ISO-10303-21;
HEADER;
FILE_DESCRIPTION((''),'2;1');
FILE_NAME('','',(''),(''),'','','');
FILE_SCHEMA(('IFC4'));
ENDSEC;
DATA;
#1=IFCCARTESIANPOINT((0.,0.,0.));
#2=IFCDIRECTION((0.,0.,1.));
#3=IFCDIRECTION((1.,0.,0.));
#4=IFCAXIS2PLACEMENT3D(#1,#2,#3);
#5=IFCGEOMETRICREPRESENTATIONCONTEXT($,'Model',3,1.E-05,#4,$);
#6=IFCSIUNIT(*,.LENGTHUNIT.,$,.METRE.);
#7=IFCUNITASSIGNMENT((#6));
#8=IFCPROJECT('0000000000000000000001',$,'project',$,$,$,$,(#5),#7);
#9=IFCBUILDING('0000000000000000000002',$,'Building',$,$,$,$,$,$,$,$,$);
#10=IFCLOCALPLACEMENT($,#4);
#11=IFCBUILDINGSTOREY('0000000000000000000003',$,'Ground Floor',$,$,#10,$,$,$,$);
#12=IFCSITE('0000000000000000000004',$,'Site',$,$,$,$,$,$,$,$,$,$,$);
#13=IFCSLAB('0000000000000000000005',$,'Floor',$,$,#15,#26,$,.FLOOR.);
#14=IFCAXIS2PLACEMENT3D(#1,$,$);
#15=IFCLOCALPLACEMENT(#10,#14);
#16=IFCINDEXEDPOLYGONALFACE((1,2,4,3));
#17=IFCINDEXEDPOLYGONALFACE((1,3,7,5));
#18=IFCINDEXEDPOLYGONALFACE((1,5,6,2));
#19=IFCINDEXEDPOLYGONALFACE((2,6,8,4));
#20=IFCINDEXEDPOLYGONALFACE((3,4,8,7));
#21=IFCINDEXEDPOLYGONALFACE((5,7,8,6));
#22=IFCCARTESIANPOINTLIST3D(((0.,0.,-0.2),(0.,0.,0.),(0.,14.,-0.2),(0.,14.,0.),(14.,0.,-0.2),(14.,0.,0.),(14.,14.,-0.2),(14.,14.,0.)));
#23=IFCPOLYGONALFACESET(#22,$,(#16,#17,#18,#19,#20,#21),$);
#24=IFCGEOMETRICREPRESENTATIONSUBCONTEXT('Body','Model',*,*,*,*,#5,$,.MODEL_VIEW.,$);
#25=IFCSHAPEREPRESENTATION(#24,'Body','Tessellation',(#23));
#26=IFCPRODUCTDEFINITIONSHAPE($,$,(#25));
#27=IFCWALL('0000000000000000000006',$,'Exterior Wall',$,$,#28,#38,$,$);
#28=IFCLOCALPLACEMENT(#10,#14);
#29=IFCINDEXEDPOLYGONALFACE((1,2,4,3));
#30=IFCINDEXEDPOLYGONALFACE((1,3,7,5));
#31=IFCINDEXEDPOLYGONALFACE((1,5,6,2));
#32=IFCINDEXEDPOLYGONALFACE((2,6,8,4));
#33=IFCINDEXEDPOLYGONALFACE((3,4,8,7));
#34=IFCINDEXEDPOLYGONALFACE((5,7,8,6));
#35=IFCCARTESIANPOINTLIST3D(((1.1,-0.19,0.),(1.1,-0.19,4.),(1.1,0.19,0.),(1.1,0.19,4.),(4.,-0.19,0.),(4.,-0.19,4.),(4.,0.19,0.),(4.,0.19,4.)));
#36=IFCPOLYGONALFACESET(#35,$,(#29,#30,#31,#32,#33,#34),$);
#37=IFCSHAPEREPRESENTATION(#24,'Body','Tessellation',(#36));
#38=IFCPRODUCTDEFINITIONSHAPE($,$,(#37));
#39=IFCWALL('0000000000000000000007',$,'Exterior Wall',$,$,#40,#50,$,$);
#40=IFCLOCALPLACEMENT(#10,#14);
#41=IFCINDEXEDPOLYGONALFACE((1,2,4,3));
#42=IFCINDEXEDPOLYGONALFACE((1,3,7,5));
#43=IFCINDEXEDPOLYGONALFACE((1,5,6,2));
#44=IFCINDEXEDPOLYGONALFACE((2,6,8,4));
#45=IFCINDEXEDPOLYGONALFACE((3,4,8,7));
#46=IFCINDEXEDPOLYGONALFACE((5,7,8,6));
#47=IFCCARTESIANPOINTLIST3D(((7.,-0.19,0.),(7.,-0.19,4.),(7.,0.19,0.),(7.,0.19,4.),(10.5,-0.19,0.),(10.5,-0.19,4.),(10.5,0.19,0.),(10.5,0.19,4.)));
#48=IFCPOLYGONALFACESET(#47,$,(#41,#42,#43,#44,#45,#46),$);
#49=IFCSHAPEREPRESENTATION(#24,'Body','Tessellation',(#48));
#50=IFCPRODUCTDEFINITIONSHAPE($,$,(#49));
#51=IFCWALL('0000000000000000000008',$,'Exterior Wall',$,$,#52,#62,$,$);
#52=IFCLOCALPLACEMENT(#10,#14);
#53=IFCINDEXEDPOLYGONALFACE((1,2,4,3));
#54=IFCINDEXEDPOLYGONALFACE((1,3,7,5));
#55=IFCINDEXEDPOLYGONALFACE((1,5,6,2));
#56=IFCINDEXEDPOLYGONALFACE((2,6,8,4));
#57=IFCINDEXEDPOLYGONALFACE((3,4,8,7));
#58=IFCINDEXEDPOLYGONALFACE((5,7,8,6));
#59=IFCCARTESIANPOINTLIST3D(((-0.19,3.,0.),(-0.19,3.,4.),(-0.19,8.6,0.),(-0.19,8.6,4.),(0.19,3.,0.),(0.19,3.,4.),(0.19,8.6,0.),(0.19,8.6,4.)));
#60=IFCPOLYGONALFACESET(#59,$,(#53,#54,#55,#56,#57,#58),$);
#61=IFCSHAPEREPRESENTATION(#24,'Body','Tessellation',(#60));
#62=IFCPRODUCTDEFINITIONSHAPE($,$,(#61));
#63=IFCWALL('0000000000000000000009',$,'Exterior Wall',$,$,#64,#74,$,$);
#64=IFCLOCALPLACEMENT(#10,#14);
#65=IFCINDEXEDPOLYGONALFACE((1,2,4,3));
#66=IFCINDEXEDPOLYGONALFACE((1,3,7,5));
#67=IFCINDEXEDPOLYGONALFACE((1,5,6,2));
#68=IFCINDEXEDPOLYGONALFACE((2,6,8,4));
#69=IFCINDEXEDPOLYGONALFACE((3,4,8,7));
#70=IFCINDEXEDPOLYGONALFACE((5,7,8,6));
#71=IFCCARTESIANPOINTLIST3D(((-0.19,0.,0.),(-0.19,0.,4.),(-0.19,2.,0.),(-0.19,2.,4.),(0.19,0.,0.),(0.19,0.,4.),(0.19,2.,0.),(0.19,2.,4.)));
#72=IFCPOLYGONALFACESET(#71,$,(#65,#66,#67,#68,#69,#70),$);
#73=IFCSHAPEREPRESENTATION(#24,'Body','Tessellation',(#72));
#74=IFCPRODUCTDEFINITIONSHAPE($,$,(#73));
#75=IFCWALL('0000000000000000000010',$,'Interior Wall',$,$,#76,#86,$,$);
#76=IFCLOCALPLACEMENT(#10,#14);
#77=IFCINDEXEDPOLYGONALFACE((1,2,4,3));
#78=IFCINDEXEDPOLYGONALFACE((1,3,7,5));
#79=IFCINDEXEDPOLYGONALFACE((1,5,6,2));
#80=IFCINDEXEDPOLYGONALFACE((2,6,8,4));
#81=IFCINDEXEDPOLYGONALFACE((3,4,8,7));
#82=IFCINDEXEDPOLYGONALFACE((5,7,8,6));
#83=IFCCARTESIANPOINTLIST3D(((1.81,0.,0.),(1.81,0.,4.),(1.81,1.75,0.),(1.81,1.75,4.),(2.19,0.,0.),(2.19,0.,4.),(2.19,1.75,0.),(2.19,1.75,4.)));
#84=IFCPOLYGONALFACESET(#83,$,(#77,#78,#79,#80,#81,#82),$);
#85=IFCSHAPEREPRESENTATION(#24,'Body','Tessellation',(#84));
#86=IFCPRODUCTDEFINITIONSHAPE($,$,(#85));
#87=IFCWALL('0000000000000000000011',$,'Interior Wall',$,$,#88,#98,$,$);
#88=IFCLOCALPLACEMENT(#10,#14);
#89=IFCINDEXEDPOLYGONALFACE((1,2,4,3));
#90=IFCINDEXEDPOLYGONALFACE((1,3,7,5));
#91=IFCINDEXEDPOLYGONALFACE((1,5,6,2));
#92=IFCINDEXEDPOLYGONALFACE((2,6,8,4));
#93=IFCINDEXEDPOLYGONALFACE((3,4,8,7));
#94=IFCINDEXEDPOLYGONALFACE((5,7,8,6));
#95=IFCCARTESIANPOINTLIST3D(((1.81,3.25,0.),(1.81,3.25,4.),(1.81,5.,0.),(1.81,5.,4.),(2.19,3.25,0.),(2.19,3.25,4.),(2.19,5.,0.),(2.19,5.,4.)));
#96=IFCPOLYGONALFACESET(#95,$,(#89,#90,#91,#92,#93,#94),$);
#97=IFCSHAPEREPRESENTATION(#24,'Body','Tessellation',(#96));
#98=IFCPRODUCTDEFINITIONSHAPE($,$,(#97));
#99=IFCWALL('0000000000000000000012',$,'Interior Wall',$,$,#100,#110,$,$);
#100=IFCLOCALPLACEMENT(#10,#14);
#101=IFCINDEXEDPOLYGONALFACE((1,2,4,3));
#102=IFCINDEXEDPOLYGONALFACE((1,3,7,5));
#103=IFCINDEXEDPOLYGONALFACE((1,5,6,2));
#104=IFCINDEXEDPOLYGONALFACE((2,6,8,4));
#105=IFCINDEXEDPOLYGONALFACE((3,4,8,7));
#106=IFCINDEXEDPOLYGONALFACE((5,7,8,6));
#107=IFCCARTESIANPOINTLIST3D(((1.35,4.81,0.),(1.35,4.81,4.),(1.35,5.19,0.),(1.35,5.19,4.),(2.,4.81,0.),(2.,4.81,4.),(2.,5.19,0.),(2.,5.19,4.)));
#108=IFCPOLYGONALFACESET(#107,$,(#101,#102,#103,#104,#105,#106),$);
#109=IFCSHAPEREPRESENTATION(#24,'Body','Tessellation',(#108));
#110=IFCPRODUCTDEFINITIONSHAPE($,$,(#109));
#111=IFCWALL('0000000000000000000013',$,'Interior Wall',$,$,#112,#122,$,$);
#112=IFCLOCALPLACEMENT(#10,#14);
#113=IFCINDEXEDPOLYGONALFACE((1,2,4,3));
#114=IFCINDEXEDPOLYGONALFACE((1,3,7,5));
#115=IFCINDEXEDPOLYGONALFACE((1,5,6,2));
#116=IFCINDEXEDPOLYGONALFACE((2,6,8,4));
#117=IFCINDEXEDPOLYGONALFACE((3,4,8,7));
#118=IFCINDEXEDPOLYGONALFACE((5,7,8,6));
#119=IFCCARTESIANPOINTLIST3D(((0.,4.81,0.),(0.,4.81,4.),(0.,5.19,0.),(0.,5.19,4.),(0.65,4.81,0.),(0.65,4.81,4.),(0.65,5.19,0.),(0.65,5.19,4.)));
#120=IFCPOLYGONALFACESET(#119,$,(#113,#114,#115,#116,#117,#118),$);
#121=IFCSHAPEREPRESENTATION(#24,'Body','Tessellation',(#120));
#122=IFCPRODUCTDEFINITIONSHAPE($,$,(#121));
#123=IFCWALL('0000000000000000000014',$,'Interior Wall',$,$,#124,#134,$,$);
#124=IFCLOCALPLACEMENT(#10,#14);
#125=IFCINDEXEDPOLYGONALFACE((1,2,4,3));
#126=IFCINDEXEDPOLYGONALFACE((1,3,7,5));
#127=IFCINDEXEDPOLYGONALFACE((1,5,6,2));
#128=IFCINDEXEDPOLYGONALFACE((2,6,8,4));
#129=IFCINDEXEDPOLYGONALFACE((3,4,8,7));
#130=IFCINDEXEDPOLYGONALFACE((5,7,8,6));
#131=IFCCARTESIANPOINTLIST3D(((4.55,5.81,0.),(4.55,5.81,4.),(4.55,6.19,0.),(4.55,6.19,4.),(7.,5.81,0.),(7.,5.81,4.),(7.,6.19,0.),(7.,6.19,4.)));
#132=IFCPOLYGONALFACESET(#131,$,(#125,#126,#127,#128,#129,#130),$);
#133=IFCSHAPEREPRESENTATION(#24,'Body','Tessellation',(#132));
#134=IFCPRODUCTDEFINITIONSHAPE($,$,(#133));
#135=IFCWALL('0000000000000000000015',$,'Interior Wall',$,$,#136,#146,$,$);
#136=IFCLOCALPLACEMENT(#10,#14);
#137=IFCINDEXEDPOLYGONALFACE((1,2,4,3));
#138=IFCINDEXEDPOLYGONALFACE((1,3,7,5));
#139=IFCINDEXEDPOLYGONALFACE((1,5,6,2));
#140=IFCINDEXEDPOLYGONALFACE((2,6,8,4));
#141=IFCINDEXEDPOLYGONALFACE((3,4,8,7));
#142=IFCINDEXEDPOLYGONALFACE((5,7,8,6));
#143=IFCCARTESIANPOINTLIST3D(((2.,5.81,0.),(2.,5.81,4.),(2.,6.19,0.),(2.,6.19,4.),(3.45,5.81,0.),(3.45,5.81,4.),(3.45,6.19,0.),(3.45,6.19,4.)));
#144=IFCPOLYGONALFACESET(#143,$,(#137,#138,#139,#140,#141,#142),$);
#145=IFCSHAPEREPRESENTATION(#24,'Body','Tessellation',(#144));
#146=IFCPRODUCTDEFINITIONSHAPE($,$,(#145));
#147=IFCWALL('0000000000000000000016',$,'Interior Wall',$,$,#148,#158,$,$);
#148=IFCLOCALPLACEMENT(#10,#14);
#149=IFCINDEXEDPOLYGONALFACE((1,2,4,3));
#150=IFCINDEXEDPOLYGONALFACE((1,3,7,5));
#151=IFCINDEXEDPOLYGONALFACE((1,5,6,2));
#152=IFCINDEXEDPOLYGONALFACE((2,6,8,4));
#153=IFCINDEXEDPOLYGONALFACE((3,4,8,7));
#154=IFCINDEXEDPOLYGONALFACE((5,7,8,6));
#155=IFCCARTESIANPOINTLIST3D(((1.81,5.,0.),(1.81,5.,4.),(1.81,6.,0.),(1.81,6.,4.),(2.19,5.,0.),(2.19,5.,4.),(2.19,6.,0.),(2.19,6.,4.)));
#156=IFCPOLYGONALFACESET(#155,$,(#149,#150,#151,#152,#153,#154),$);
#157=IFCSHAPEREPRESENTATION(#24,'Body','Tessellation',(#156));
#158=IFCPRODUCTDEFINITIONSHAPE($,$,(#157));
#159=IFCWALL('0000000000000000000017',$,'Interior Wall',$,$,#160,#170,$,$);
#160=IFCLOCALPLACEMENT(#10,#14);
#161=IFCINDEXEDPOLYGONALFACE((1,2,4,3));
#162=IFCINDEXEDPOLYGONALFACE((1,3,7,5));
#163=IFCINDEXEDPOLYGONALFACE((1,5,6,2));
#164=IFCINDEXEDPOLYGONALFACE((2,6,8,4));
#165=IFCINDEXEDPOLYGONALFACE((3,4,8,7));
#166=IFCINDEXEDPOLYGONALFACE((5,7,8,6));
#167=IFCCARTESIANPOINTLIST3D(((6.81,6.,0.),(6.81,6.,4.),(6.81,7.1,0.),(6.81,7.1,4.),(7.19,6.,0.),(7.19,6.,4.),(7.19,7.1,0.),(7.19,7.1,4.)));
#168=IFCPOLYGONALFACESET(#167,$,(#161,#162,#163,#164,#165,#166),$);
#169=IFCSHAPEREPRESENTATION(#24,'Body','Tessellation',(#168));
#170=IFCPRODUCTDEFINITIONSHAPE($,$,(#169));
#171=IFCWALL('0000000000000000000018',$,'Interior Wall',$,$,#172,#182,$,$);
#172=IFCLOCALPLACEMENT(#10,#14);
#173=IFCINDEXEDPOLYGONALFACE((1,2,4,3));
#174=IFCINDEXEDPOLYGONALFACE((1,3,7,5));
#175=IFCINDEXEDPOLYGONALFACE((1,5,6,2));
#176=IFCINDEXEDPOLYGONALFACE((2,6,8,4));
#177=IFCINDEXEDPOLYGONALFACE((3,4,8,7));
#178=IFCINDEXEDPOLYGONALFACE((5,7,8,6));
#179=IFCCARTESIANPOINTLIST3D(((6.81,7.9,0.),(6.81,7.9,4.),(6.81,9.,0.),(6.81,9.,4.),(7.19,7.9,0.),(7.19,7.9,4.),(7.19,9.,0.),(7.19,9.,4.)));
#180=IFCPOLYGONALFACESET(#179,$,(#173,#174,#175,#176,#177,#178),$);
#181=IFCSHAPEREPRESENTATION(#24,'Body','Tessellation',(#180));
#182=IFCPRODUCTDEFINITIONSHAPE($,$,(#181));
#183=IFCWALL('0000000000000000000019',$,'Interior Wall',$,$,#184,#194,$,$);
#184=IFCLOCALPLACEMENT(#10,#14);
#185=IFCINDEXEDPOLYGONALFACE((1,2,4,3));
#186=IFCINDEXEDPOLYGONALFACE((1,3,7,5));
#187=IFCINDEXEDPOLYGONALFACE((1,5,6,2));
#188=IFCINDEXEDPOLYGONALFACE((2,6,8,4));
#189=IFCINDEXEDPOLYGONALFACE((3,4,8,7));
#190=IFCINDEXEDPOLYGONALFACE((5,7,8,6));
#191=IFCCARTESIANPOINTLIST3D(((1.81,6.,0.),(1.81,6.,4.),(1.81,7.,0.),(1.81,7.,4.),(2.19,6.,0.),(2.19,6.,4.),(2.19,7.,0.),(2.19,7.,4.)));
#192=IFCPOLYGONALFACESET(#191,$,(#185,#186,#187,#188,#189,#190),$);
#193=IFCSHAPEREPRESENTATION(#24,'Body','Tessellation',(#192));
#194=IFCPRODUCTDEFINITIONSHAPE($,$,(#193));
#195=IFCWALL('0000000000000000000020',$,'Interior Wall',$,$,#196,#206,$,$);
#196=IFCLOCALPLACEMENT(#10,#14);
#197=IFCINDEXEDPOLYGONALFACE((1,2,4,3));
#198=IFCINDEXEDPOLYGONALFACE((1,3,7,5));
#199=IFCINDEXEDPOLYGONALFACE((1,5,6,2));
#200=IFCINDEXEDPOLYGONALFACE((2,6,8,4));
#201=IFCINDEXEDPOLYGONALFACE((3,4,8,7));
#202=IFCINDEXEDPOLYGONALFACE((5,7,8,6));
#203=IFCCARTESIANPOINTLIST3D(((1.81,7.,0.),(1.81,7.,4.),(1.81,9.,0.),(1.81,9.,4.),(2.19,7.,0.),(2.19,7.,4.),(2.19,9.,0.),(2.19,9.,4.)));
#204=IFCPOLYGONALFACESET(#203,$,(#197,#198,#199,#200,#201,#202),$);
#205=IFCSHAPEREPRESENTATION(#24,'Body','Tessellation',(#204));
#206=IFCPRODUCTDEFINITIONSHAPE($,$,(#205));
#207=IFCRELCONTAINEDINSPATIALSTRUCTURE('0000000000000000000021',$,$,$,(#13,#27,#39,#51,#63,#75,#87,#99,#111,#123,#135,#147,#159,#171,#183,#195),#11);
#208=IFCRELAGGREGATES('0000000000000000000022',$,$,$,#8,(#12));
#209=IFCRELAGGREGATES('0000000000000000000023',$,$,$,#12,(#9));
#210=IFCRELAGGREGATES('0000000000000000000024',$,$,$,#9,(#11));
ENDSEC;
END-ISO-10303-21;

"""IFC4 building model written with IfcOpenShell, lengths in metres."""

from ifc_helpers import new_model, si_unit, frame, origin_with_axes, place, context, subcontext, project, spatial, indexed_curve, outline, extrude, element, save


model = new_model("IFC4")

# Units and contexts
model_context = context("Model", 3, precision=1e-05, world=origin_with_axes())
body_context = subcontext(model_context, "Body", "Model", "MODEL_VIEW")
ifc_project = project(units=[si_unit("LENGTHUNIT", "METRE")], contexts=[model_context])

# Site, building, storey
site = spatial("IfcSite", under=ifc_project, Name="Site")
building = spatial("IfcBuilding", under=site, Name="Building")
storey_placement = place(None, origin_with_axes())
storey = spatial("IfcBuildingStorey", under=building, at=storey_placement, Name="Ground Floor")

# Slab
slab_placement = place(storey_placement, frame((0.0, 0.0, -0.2), z_axis=(0.0, 0.0, 1.0), x_axis=(1.0, 0.0, 0.0)))
element("IfcSlab", 1, at=slab_placement, inside=storey, Name="Floor", PredefinedType="FLOOR", context=body_context, shape_type="SweptSolid", body=[
    extrude(outline(indexed_curve([(0.0, 0.0), (14.0, 0.0), (14.0, 14.0), (0.0, 14.0)])), None, (0.0, 0.0, 1.0), 0.2),
])

# Walls
wall_1_placement = place(storey_placement, frame((1.1, 0.0, 0.0), z_axis=(0.0, 0.0, 1.0), x_axis=(1.0, 0.0, 0.0)))
element("IfcWall", 2, at=wall_1_placement, inside=storey, Name="Exterior Wall", context=body_context, shape_type="SweptSolid", body=[
    extrude(outline(indexed_curve([(0.0, 0.0), (0.0, 0.38), (2.9, 0.38), (2.9, 0.0), (0.0, 0.0)], self_intersect=False)), frame((0.0, -0.19, 0.0), z_axis=(0.0, 0.0, 1.0), x_axis=(1.0, 0.0, 0.0)), (0.0, 0.0, 1.0), 4.0),
])
wall_2_placement = place(storey_placement, frame((7.0, 0.0, 0.0), z_axis=(0.0, 0.0, 1.0), x_axis=(1.0, 0.0, 0.0)))
element("IfcWall", 3, at=wall_2_placement, inside=storey, Name="Exterior Wall", context=body_context, shape_type="SweptSolid", body=[
    extrude(outline(indexed_curve([(0.0, 0.0), (0.0, 0.38), (3.5, 0.38), (3.5, 0.0), (0.0, 0.0)], self_intersect=False)), frame((0.0, -0.19, 0.0), z_axis=(0.0, 0.0, 1.0), x_axis=(1.0, 0.0, 0.0)), (0.0, 0.0, 1.0), 4.0),
])
wall_3_placement = place(storey_placement, frame((0.0, 8.6, 0.0), z_axis=(0.0, 0.0, 1.0), x_axis=(0.0, -1.0, 0.0)))
element("IfcWall", 4, at=wall_3_placement, inside=storey, Name="Exterior Wall", context=body_context, shape_type="SweptSolid", body=[
    extrude(outline(indexed_curve([(0.0, 0.0), (0.0, 0.38), (5.6, 0.38), (5.6, 0.0), (0.0, 0.0)], self_intersect=False)), frame((0.0, -0.19, 0.0), z_axis=(0.0, 0.0, 1.0), x_axis=(1.0, 0.0, 0.0)), (0.0, 0.0, 1.0), 4.0),
])
wall_4_placement = place(storey_placement, frame((0.0, 2.0, 0.0), z_axis=(0.0, 0.0, 1.0), x_axis=(0.0, -1.0, 0.0)))
element("IfcWall", 5, at=wall_4_placement, inside=storey, Name="Exterior Wall", context=body_context, shape_type="SweptSolid", body=[
    extrude(outline(indexed_curve([(0.0, 0.0), (0.0, 0.38), (2.0, 0.38), (2.0, 0.0), (0.0, 0.0)], self_intersect=False)), frame((0.0, -0.19, 0.0), z_axis=(0.0, 0.0, 1.0), x_axis=(1.0, 0.0, 0.0)), (0.0, 0.0, 1.0), 4.0),
])
for number, where, z_axis, x_axis, name in (
    (6, (2.0, 0.0, 0.0), (0.0, 0.0, 1.0), (0.0, 1.0, 0.0), "Interior Wall"),
    (7, (2.0, 3.25, 0.0), (0.0, 0.0, 1.0), (0.0, 1.0, 0.0), "Interior Wall"),
):
    element("IfcWall", number, at=place(storey_placement, frame(where, z_axis=z_axis, x_axis=x_axis)), inside=storey, Name=name, context=body_context, shape_type="SweptSolid", body=[
        extrude(outline(indexed_curve([(0.0, 0.0), (0.0, 0.38), (1.75, 0.38), (1.75, 0.0), (0.0, 0.0)], self_intersect=False)), frame((0.0, -0.19, 0.0), z_axis=(0.0, 0.0, 1.0), x_axis=(1.0, 0.0, 0.0)), (0.0, 0.0, 1.0), 4.0),
    ])
for number, where, z_axis, x_axis, name in (
    (8, (2.0, 5.0, 0.0), (0.0, 0.0, 1.0), (-1.0, 0.0, 0.0), "Interior Wall"),
    (9, (0.65, 5.0, 0.0), (0.0, 0.0, 1.0), (-1.0, 0.0, 0.0), "Interior Wall"),
):
    element("IfcWall", number, at=place(storey_placement, frame(where, z_axis=z_axis, x_axis=x_axis)), inside=storey, Name=name, context=body_context, shape_type="SweptSolid", body=[
        extrude(outline(indexed_curve([(0.0, 0.0), (0.0, 0.38), (0.65, 0.38), (0.65, 0.0), (0.0, 0.0)], self_intersect=False)), frame((0.0, -0.19, 0.0), z_axis=(0.0, 0.0, 1.0), x_axis=(1.0, 0.0, 0.0)), (0.0, 0.0, 1.0), 4.0),
    ])
wall_5_placement = place(storey_placement, frame((7.0, 6.0, 0.0), z_axis=(0.0, 0.0, 1.0), x_axis=(-1.0, 0.0, 0.0)))
element("IfcWall", 10, at=wall_5_placement, inside=storey, Name="Interior Wall", context=body_context, shape_type="SweptSolid", body=[
    extrude(outline(indexed_curve([(0.0, 0.0), (0.0, 0.38), (2.45, 0.38), (2.45, 0.0), (0.0, 0.0)], self_intersect=False)), frame((0.0, -0.19, 0.0), z_axis=(0.0, 0.0, 1.0), x_axis=(1.0, 0.0, 0.0)), (0.0, 0.0, 1.0), 4.0),
])
wall_6_placement = place(storey_placement, frame((3.45, 6.0, 0.0), z_axis=(0.0, 0.0, 1.0), x_axis=(-1.0, 0.0, 0.0)))
element("IfcWall", 11, at=wall_6_placement, inside=storey, Name="Interior Wall", context=body_context, shape_type="SweptSolid", body=[
    extrude(outline(indexed_curve([(0.0, 0.0), (0.0, 0.38), (1.45, 0.38), (1.45, 0.0), (0.0, 0.0)], self_intersect=False)), frame((0.0, -0.19, 0.0), z_axis=(0.0, 0.0, 1.0), x_axis=(1.0, 0.0, 0.0)), (0.0, 0.0, 1.0), 4.0),
])
wall_7_placement = place(storey_placement, frame((2.0, 6.0, 0.0), z_axis=(0.0, 0.0, 1.0), x_axis=(0.0, -1.0, 0.0)))
element("IfcWall", 12, at=wall_7_placement, inside=storey, Name="Interior Wall", context=body_context, shape_type="SweptSolid", body=[
    extrude(outline(indexed_curve([(0.0, 0.0), (0.0, 0.38), (1.0, 0.38), (1.0, 0.0), (0.0, 0.0)], self_intersect=False)), frame((0.0, -0.19, 0.0), z_axis=(0.0, 0.0, 1.0), x_axis=(1.0, 0.0, 0.0)), (0.0, 0.0, 1.0), 4.0),
])
for number, where, z_axis, x_axis, name in (
    (13, (7.0, 6.0, 0.0), (0.0, 0.0, 1.0), (0.0, 1.0, 0.0), "Interior Wall"),
    (14, (7.0, 7.9, 0.0), (0.0, 0.0, 1.0), (0.0, 1.0, 0.0), "Interior Wall"),
):
    element("IfcWall", number, at=place(storey_placement, frame(where, z_axis=z_axis, x_axis=x_axis)), inside=storey, Name=name, context=body_context, shape_type="SweptSolid", body=[
        extrude(outline(indexed_curve([(0.0, 0.0), (0.0, 0.38), (1.1, 0.38), (1.1, 0.0), (0.0, 0.0)], self_intersect=False)), frame((0.0, -0.19, 0.0), z_axis=(0.0, 0.0, 1.0), x_axis=(1.0, 0.0, 0.0)), (0.0, 0.0, 1.0), 4.0),
    ])
wall_8_placement = place(storey_placement, frame((2.0, 7.0, 0.0), z_axis=(0.0, 0.0, 1.0), x_axis=(0.0, -1.0, 0.0)))
element("IfcWall", 15, at=wall_8_placement, inside=storey, Name="Interior Wall", context=body_context, shape_type="SweptSolid", body=[
    extrude(outline(indexed_curve([(0.0, 0.0), (0.0, 0.38), (1.0, 0.38), (1.0, 0.0), (0.0, 0.0)], self_intersect=False)), frame((0.0, -0.19, 0.0), z_axis=(0.0, 0.0, 1.0), x_axis=(1.0, 0.0, 0.0)), (0.0, 0.0, 1.0), 4.0),
])
wall_9_placement = place(storey_placement, frame((2.0, 9.0, 0.0), z_axis=(0.0, 0.0, 1.0), x_axis=(0.0, -1.0, 0.0)))
element("IfcWall", 16, at=wall_9_placement, inside=storey, Name="Interior Wall", context=body_context, shape_type="SweptSolid", body=[
    extrude(outline(indexed_curve([(0.0, 0.0), (0.0, 0.38), (2.0, 0.38), (2.0, 0.0), (0.0, 0.0)], self_intersect=False)), frame((0.0, -0.19, 0.0), z_axis=(0.0, 0.0, 1.0), x_axis=(1.0, 0.0, 0.0)), (0.0, 0.0, 1.0), 4.0),
])

save(model, "model.ifc")
